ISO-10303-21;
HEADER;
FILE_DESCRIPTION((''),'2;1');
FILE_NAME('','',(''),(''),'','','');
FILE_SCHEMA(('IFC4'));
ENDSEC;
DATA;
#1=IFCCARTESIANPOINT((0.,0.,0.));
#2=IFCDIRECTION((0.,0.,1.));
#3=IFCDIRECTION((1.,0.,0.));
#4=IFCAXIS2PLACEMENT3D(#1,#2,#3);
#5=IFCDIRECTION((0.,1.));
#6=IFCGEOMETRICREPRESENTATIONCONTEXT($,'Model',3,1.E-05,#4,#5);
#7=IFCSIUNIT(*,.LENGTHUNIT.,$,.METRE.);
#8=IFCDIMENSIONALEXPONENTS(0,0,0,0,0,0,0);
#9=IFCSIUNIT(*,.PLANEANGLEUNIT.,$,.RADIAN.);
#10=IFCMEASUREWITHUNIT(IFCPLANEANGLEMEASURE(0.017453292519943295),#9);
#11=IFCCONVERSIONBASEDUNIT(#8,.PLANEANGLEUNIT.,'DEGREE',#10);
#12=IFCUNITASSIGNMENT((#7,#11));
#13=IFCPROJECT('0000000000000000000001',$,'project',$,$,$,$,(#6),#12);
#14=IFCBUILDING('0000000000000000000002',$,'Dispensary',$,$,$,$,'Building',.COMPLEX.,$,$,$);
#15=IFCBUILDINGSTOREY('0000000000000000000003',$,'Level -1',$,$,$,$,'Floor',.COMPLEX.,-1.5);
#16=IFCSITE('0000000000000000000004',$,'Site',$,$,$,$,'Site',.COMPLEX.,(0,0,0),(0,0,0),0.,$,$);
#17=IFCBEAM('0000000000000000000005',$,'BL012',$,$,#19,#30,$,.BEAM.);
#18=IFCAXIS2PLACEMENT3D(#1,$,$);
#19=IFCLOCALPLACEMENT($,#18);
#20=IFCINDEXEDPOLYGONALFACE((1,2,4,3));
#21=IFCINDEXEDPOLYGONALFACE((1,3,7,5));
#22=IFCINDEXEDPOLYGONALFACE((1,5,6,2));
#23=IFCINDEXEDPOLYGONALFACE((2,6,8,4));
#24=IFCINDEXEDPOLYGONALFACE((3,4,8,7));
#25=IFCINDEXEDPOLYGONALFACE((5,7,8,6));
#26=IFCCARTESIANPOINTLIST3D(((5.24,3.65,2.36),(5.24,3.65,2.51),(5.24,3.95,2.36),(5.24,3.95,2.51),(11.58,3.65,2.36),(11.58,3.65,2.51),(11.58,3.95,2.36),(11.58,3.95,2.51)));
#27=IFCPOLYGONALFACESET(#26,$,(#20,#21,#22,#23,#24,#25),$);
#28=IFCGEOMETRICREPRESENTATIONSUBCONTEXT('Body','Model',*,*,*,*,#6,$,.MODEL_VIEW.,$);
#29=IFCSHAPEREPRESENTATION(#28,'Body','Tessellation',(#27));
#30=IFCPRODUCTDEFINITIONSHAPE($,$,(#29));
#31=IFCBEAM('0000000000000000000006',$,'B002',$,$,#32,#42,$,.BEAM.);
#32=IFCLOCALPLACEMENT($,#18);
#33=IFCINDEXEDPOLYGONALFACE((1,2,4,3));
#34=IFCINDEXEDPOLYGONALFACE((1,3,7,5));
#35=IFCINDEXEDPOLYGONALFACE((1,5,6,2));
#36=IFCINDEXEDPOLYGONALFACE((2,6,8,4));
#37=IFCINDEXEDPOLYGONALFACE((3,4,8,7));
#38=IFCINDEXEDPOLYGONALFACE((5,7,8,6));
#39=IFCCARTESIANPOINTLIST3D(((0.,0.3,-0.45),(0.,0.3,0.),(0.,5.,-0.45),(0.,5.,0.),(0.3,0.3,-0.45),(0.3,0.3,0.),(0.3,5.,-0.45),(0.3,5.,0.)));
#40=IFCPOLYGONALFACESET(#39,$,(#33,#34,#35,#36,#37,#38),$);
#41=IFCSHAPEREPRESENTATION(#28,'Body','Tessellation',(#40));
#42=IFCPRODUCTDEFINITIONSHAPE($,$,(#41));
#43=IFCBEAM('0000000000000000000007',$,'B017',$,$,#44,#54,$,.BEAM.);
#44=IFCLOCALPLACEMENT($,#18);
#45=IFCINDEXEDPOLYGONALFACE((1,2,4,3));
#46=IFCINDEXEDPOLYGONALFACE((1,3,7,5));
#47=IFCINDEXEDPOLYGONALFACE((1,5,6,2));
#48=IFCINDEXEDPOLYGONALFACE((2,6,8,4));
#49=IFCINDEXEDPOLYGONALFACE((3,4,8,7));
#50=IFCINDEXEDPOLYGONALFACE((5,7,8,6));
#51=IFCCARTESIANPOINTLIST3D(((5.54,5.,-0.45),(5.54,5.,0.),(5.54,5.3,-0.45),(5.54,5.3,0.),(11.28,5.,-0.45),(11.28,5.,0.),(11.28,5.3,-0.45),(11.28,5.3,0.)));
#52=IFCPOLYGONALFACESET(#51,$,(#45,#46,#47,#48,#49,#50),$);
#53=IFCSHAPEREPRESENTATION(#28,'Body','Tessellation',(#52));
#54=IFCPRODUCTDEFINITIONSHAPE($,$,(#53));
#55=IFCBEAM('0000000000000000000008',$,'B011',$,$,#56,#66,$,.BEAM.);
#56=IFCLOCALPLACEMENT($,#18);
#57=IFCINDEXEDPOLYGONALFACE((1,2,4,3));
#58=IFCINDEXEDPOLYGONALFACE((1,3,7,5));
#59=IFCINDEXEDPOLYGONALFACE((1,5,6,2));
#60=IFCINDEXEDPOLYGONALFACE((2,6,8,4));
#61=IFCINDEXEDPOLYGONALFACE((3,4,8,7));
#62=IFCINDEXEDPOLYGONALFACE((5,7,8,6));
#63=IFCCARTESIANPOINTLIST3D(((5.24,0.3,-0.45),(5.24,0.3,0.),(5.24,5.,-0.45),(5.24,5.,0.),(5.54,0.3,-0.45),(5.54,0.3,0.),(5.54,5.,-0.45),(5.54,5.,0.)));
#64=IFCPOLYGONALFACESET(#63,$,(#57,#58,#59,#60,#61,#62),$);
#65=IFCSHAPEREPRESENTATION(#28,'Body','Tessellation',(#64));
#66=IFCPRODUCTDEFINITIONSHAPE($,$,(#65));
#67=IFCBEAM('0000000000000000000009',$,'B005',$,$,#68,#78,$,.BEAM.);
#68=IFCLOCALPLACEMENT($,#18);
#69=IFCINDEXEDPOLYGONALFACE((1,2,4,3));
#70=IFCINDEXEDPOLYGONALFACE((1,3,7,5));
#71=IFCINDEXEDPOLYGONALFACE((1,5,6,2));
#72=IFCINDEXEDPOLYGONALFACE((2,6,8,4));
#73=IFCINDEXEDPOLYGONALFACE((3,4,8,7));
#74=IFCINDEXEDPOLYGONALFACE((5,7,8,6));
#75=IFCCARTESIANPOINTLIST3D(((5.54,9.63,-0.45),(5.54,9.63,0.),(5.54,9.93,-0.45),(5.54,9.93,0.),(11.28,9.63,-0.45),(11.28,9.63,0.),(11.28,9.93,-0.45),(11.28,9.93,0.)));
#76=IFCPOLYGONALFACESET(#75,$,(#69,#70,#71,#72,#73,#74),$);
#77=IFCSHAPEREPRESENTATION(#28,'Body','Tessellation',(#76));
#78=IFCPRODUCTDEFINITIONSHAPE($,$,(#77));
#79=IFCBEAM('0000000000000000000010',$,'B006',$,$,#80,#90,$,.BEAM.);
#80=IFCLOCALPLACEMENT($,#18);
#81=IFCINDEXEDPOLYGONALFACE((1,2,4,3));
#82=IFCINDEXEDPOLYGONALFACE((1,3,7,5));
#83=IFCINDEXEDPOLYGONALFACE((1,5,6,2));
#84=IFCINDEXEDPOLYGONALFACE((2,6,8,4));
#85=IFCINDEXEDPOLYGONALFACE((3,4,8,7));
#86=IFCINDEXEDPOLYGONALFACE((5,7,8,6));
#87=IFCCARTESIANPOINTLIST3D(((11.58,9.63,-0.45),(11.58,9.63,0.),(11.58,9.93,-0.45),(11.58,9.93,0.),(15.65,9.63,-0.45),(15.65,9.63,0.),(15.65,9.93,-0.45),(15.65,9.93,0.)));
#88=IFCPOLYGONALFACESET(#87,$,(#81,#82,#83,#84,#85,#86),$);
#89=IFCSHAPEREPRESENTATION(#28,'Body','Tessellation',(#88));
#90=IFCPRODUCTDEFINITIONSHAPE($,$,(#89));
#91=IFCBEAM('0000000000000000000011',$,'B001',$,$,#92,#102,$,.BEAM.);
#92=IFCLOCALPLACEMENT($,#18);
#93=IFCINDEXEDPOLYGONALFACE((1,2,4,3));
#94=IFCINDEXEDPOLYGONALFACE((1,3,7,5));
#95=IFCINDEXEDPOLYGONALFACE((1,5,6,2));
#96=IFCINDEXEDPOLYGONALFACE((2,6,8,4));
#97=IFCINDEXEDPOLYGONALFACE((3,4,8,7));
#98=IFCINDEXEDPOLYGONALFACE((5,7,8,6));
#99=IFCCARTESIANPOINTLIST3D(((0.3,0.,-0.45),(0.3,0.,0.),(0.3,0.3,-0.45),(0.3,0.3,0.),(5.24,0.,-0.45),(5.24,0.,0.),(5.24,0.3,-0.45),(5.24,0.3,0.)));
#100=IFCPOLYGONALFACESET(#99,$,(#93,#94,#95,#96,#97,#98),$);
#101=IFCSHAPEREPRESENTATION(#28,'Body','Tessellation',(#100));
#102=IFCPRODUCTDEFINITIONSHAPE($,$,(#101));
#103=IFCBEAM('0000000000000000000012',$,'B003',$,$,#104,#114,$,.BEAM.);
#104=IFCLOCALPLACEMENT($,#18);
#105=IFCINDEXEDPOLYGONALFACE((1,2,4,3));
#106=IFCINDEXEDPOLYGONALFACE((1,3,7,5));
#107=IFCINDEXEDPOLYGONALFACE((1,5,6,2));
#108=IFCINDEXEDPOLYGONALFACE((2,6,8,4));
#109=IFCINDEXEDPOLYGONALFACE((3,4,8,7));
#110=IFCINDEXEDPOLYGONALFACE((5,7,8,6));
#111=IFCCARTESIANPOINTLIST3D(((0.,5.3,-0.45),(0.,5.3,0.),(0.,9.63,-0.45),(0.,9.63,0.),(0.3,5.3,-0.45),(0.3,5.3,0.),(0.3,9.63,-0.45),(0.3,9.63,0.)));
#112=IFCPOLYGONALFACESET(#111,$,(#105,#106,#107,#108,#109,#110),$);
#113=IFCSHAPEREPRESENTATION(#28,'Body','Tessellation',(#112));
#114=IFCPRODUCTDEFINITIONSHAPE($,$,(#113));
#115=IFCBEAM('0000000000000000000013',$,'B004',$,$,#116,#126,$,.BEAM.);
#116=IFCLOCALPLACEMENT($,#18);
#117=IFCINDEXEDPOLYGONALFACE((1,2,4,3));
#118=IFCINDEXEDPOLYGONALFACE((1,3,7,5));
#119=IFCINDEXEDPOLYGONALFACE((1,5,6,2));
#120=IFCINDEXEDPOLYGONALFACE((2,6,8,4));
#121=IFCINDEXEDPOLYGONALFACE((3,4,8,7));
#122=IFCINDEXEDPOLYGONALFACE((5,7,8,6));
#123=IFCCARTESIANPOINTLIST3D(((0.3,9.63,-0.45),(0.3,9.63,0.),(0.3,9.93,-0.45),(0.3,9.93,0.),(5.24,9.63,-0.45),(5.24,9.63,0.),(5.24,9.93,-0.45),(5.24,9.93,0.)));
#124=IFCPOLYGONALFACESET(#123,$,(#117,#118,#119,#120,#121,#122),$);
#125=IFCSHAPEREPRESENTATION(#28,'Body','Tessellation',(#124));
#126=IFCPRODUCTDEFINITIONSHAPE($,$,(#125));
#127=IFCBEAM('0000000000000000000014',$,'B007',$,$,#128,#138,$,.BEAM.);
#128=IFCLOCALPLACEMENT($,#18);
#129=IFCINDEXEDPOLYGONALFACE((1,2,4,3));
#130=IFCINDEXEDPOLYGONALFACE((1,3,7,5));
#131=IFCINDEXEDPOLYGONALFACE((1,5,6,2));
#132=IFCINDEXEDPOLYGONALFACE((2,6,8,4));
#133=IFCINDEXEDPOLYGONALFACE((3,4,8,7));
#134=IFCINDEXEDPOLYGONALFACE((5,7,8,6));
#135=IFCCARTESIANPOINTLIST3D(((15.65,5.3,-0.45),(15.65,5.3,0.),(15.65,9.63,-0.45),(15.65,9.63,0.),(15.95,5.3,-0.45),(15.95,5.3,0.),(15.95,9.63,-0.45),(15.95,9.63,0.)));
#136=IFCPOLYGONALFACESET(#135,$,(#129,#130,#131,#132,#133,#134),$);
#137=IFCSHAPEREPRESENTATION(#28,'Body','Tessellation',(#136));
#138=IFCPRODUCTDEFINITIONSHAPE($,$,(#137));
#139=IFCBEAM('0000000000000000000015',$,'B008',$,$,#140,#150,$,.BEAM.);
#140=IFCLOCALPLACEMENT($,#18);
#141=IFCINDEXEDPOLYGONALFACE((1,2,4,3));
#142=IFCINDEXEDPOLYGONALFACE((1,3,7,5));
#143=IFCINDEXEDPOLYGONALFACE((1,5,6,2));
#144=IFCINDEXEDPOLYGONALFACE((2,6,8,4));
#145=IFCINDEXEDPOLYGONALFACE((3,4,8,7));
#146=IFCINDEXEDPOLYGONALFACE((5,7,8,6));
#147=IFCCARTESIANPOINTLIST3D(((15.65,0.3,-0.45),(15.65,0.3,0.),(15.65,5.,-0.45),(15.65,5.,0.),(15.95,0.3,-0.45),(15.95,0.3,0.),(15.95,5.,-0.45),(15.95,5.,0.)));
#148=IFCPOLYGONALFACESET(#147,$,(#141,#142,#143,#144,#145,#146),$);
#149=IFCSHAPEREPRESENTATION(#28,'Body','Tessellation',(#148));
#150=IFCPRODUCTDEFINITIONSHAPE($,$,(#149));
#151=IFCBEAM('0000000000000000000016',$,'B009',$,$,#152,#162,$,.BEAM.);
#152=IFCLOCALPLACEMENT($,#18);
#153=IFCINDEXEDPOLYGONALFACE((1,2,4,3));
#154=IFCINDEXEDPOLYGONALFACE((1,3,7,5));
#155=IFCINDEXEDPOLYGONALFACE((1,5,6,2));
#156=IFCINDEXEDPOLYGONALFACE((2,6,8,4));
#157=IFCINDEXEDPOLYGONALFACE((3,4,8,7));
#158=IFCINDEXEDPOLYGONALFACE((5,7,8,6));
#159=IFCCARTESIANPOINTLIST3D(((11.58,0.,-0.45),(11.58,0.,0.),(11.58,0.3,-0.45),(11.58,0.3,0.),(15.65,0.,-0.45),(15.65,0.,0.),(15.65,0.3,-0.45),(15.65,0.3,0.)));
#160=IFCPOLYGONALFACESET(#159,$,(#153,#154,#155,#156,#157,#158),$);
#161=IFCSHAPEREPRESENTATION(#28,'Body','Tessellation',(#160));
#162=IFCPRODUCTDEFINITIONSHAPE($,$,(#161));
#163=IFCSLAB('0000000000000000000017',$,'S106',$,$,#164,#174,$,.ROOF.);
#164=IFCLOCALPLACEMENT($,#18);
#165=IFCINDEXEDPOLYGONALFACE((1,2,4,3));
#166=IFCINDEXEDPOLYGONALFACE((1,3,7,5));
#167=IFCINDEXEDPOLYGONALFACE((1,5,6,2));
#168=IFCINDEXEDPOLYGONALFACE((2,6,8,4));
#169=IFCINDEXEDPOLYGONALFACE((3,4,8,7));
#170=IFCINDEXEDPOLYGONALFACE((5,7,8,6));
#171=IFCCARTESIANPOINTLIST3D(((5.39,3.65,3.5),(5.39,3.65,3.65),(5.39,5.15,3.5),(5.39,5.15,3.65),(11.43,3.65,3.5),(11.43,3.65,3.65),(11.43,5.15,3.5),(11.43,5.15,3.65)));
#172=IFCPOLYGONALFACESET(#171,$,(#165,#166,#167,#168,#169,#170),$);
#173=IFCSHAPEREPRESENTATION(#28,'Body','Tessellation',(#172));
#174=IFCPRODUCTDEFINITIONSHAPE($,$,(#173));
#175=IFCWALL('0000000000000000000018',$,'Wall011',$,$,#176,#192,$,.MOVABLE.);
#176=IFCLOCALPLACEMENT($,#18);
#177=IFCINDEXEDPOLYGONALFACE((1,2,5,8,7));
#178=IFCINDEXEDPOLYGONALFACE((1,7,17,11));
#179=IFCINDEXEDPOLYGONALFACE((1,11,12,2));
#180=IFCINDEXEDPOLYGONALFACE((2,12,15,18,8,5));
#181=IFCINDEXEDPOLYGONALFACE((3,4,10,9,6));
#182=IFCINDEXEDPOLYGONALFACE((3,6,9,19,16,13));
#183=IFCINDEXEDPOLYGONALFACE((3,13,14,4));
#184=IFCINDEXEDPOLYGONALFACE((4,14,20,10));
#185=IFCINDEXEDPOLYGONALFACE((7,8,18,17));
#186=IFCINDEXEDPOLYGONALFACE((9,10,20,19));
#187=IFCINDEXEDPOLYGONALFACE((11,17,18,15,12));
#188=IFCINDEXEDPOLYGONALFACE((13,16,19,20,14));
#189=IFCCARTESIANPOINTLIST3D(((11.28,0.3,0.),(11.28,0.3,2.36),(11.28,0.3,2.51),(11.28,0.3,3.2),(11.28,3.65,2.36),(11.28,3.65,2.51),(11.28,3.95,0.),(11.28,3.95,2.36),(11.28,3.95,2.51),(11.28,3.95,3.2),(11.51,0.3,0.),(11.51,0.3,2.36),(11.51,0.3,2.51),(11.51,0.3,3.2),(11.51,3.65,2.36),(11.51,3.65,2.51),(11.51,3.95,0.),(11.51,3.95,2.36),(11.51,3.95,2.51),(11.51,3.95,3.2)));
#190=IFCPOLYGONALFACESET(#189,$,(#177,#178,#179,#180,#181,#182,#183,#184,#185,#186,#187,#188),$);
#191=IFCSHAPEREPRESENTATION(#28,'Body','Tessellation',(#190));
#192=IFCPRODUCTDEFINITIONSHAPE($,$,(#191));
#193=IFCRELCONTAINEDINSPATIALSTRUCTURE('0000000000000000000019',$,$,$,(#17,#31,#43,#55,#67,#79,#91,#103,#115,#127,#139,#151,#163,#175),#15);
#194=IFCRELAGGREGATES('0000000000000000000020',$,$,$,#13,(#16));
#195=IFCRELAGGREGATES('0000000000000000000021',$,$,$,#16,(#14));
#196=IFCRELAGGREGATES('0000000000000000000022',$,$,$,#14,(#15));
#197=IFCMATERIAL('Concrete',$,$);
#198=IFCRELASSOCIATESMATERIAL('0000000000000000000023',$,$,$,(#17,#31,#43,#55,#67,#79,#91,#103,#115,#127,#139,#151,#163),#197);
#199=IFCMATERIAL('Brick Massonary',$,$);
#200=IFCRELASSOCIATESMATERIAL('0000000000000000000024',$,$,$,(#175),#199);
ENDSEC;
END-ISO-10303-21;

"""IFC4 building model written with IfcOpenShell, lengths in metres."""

from ifc_helpers import new_model, entity, si_unit, converted_unit, direction, frame, frame_2d, origin_with_axes, place, context, subcontext, project, spatial, rectangle, extrude, material, element, save


model = new_model("IFC4")

# Units and contexts
model_context = context("Model", 3, precision=1e-05, world=origin_with_axes(), true_north=direction((0.0, 1.0)))
body_context = subcontext(model_context, "Body", "Model", "MODEL_VIEW")
ifc_project = project(units=[si_unit("LENGTHUNIT", "METRE"), converted_unit("PLANEANGLEUNIT", "DEGREE", entity("IfcPlaneAngleMeasure", 0.017453292519943295), si_unit("PLANEANGLEUNIT", "RADIAN"), dimensions=[0, 0, 0, 0, 0, 0, 0])], contexts=[model_context])

# Site, building, storey
site = spatial("IfcSite", under=ifc_project, Name="Site", LongName="Site", CompositionType="COMPLEX", RefLatitude=(0, 0, 0), RefLongitude=(0, 0, 0), RefElevation=0.0)
building = spatial("IfcBuilding", under=site, Name="Dispensary", LongName="Building", CompositionType="COMPLEX")
storey = spatial("IfcBuildingStorey", under=building, Name="Level -1", LongName="Floor", CompositionType="COMPLEX", Elevation=-1.5)

# Beam
ifc_material_1 = material(Name="Concrete")
placement = place(None, origin_with_axes())
element("IfcBeam", 1, at=placement, inside=storey, material=ifc_material_1, Name="BL012", PredefinedType="BEAM", context=body_context, shape_type="SweptSolid", body=[
    extrude(rectangle(XDim=0.3, YDim=0.15, at=frame_2d((0.0, 0.0), x_axis=(0.0, 1.0))), frame((11.58, 3.8, 2.435), z_axis=(-1.0, 0.0, 0.0), x_axis=(0.0, 0.0, -1.0)), (0.0, 0.0, 1.0), 6.34),
])

# Beams
element("IfcBeam", 2, at=placement, inside=storey, material=ifc_material_1, Name="B002", PredefinedType="BEAM", context=body_context, shape_type="SweptSolid", body=[
    extrude(rectangle(XDim=0.3, YDim=0.45, at=frame_2d((0.0, 0.0), x_axis=(0.0, 1.0))), frame((0.15, 0.3, -0.225), z_axis=(0.0, 1.0, 0.0), x_axis=(0.0, 0.0, -1.0)), (0.0, 0.0, 1.0), 4.7),
])
element("IfcBeam", 3, at=placement, inside=storey, material=ifc_material_1, Name="B017", PredefinedType="BEAM", context=body_context, shape_type="SweptSolid", body=[
    extrude(rectangle(XDim=0.3, YDim=0.45, at=frame_2d((0.0, 0.0), x_axis=(0.0, 1.0))), frame((5.54, 5.15, -0.225), z_axis=(1.0, 0.0, 0.0), x_axis=(0.0, 0.0, -1.0)), (0.0, 0.0, 1.0), 5.74),
])
element("IfcBeam", 4, at=placement, inside=storey, material=ifc_material_1, Name="B011", PredefinedType="BEAM", context=body_context, shape_type="SweptSolid", body=[
    extrude(rectangle(XDim=0.3, YDim=0.45, at=frame_2d((0.0, 0.0), x_axis=(0.0, 1.0))), frame((5.39, 0.3, -0.225), z_axis=(0.0, 1.0, 0.0), x_axis=(0.0, 0.0, -1.0)), (0.0, 0.0, 1.0), 4.7),
])
element("IfcBeam", 5, at=placement, inside=storey, material=ifc_material_1, Name="B005", PredefinedType="BEAM", context=body_context, shape_type="SweptSolid", body=[
    extrude(rectangle(XDim=0.3, YDim=0.45, at=frame_2d((0.0, 0.0), x_axis=(0.0, 1.0))), frame((5.54, 9.78, -0.225), z_axis=(1.0, 0.0, 0.0), x_axis=(0.0, 0.0, -1.0)), (0.0, 0.0, 1.0), 5.74),
])
element("IfcBeam", 6, at=placement, inside=storey, material=ifc_material_1, Name="B006", PredefinedType="BEAM", context=body_context, shape_type="SweptSolid", body=[
    extrude(rectangle(XDim=0.3, YDim=0.45, at=frame_2d((0.0, 0.0), x_axis=(0.0, 1.0))), frame((11.58, 9.78, -0.225), z_axis=(1.0, 0.0, 0.0), x_axis=(0.0, 0.0, -1.0)), (0.0, 0.0, 1.0), 4.07),
])
element("IfcBeam", 7, at=placement, inside=storey, material=ifc_material_1, Name="B001", PredefinedType="BEAM", context=body_context, shape_type="SweptSolid", body=[
    extrude(rectangle(XDim=0.3, YDim=0.45, at=frame_2d((0.0, 0.0), x_axis=(0.0, 1.0))), frame((0.3, 0.15, -0.225), z_axis=(1.0, 0.0, 0.0), x_axis=(0.0, 0.0, -1.0)), (0.0, 0.0, 1.0), 4.94),
])
element("IfcBeam", 8, at=placement, inside=storey, material=ifc_material_1, Name="B003", PredefinedType="BEAM", context=body_context, shape_type="SweptSolid", body=[
    extrude(rectangle(XDim=0.3, YDim=0.45, at=frame_2d((0.0, 0.0), x_axis=(0.0, 1.0))), frame((0.15, 5.3, -0.225), z_axis=(0.0, 1.0, 0.0), x_axis=(0.0, 0.0, -1.0)), (0.0, 0.0, 1.0), 4.33),
])
element("IfcBeam", 9, at=placement, inside=storey, material=ifc_material_1, Name="B004", PredefinedType="BEAM", context=body_context, shape_type="SweptSolid", body=[
    extrude(rectangle(XDim=0.3, YDim=0.45, at=frame_2d((0.0, 0.0), x_axis=(0.0, 1.0))), frame((0.3, 9.78, -0.225), z_axis=(1.0, 0.0, 0.0), x_axis=(0.0, 0.0, -1.0)), (0.0, 0.0, 1.0), 4.94),
])
element("IfcBeam", 10, at=placement, inside=storey, material=ifc_material_1, Name="B007", PredefinedType="BEAM", context=body_context, shape_type="SweptSolid", body=[
    extrude(rectangle(XDim=0.3, YDim=0.45, at=frame_2d((0.0, 0.0), x_axis=(0.0, 1.0))), frame((15.8, 9.63, -0.225), z_axis=(0.0, -1.0, 0.0), x_axis=(0.0, 0.0, -1.0)), (0.0, 0.0, 1.0), 4.33),
])
element("IfcBeam", 11, at=placement, inside=storey, material=ifc_material_1, Name="B008", PredefinedType="BEAM", context=body_context, shape_type="SweptSolid", body=[
    extrude(rectangle(XDim=0.3, YDim=0.45, at=frame_2d((0.0, 0.0), x_axis=(0.0, 1.0))), frame((15.8, 5.0, -0.225), z_axis=(0.0, -1.0, 0.0), x_axis=(0.0, 0.0, -1.0)), (0.0, 0.0, 1.0), 4.7),
])
element("IfcBeam", 12, at=placement, inside=storey, material=ifc_material_1, Name="B009", PredefinedType="BEAM", context=body_context, shape_type="SweptSolid", body=[
    extrude(rectangle(XDim=0.3, YDim=0.45, at=frame_2d((0.0, 0.0), x_axis=(0.0, 1.0))), frame((15.65, 0.15, -0.225), z_axis=(-1.0, 0.0, 0.0), x_axis=(0.0, 0.0, -1.0)), (0.0, 0.0, 1.0), 4.07),
])

# Slab
element("IfcSlab", 13, at=placement, inside=storey, material=ifc_material_1, Name="S106", PredefinedType="ROOF", context=body_context, shape_type="SweptSolid", body=[
    extrude(rectangle(XDim=6.04, YDim=1.5, at=frame_2d((0.0, 0.0), x_axis=(-1.0, 0.0))), frame((8.41, 4.4, 3.5), z_axis=(0.0, 0.0, 1.0), x_axis=(1.0, 0.0, 0.0)), (0.0, 0.0, 1.0), 0.15),
])

# Wall, openings
ifc_material_2 = material(Name="Brick Massonary")
wall_1 = element("IfcWall", 14, at=placement, inside=storey, material=ifc_material_2, Name="Wall011", PredefinedType="MOVABLE", context=body_context, shape_type="SweptSolid", body=[
    extrude(rectangle(XDim=3.65, YDim=0.23, at=frame_2d((0.0, 0.0), x_axis=(0.0, -1.0))), frame((11.395, 2.125, 0.0), z_axis=(0.0, 0.0, 1.0), x_axis=(1.0, 0.0, 0.0)), (0.0, 0.0, 1.0), 3.2),
])
element("IfcOpeningElement", 15, at=placement, cuts=wall_1, context=body_context, shape_type="SweptSolid", body=[
    extrude(rectangle(XDim=0.3, YDim=0.15, at=frame_2d((0.0, 0.0), x_axis=(0.0, 1.0))), frame((11.43, 0.3, 2.435), z_axis=(0.0, 1.0, 0.0), x_axis=(0.0, 0.0, -1.0)), (0.0, 0.0, 1.0), 3.35),
])
element("IfcOpeningElement", 16, at=placement, cuts=wall_1, context=body_context, shape_type="SweptSolid", body=[
    extrude(rectangle(XDim=0.3, YDim=0.15, at=frame_2d((0.0, 0.0), x_axis=(0.0, 1.0))), frame((11.58, 3.8, 2.435), z_axis=(-1.0, 0.0, 0.0), x_axis=(0.0, 0.0, -1.0)), (0.0, 0.0, 1.0), 6.34),
])

save(model, "model.ifc")
